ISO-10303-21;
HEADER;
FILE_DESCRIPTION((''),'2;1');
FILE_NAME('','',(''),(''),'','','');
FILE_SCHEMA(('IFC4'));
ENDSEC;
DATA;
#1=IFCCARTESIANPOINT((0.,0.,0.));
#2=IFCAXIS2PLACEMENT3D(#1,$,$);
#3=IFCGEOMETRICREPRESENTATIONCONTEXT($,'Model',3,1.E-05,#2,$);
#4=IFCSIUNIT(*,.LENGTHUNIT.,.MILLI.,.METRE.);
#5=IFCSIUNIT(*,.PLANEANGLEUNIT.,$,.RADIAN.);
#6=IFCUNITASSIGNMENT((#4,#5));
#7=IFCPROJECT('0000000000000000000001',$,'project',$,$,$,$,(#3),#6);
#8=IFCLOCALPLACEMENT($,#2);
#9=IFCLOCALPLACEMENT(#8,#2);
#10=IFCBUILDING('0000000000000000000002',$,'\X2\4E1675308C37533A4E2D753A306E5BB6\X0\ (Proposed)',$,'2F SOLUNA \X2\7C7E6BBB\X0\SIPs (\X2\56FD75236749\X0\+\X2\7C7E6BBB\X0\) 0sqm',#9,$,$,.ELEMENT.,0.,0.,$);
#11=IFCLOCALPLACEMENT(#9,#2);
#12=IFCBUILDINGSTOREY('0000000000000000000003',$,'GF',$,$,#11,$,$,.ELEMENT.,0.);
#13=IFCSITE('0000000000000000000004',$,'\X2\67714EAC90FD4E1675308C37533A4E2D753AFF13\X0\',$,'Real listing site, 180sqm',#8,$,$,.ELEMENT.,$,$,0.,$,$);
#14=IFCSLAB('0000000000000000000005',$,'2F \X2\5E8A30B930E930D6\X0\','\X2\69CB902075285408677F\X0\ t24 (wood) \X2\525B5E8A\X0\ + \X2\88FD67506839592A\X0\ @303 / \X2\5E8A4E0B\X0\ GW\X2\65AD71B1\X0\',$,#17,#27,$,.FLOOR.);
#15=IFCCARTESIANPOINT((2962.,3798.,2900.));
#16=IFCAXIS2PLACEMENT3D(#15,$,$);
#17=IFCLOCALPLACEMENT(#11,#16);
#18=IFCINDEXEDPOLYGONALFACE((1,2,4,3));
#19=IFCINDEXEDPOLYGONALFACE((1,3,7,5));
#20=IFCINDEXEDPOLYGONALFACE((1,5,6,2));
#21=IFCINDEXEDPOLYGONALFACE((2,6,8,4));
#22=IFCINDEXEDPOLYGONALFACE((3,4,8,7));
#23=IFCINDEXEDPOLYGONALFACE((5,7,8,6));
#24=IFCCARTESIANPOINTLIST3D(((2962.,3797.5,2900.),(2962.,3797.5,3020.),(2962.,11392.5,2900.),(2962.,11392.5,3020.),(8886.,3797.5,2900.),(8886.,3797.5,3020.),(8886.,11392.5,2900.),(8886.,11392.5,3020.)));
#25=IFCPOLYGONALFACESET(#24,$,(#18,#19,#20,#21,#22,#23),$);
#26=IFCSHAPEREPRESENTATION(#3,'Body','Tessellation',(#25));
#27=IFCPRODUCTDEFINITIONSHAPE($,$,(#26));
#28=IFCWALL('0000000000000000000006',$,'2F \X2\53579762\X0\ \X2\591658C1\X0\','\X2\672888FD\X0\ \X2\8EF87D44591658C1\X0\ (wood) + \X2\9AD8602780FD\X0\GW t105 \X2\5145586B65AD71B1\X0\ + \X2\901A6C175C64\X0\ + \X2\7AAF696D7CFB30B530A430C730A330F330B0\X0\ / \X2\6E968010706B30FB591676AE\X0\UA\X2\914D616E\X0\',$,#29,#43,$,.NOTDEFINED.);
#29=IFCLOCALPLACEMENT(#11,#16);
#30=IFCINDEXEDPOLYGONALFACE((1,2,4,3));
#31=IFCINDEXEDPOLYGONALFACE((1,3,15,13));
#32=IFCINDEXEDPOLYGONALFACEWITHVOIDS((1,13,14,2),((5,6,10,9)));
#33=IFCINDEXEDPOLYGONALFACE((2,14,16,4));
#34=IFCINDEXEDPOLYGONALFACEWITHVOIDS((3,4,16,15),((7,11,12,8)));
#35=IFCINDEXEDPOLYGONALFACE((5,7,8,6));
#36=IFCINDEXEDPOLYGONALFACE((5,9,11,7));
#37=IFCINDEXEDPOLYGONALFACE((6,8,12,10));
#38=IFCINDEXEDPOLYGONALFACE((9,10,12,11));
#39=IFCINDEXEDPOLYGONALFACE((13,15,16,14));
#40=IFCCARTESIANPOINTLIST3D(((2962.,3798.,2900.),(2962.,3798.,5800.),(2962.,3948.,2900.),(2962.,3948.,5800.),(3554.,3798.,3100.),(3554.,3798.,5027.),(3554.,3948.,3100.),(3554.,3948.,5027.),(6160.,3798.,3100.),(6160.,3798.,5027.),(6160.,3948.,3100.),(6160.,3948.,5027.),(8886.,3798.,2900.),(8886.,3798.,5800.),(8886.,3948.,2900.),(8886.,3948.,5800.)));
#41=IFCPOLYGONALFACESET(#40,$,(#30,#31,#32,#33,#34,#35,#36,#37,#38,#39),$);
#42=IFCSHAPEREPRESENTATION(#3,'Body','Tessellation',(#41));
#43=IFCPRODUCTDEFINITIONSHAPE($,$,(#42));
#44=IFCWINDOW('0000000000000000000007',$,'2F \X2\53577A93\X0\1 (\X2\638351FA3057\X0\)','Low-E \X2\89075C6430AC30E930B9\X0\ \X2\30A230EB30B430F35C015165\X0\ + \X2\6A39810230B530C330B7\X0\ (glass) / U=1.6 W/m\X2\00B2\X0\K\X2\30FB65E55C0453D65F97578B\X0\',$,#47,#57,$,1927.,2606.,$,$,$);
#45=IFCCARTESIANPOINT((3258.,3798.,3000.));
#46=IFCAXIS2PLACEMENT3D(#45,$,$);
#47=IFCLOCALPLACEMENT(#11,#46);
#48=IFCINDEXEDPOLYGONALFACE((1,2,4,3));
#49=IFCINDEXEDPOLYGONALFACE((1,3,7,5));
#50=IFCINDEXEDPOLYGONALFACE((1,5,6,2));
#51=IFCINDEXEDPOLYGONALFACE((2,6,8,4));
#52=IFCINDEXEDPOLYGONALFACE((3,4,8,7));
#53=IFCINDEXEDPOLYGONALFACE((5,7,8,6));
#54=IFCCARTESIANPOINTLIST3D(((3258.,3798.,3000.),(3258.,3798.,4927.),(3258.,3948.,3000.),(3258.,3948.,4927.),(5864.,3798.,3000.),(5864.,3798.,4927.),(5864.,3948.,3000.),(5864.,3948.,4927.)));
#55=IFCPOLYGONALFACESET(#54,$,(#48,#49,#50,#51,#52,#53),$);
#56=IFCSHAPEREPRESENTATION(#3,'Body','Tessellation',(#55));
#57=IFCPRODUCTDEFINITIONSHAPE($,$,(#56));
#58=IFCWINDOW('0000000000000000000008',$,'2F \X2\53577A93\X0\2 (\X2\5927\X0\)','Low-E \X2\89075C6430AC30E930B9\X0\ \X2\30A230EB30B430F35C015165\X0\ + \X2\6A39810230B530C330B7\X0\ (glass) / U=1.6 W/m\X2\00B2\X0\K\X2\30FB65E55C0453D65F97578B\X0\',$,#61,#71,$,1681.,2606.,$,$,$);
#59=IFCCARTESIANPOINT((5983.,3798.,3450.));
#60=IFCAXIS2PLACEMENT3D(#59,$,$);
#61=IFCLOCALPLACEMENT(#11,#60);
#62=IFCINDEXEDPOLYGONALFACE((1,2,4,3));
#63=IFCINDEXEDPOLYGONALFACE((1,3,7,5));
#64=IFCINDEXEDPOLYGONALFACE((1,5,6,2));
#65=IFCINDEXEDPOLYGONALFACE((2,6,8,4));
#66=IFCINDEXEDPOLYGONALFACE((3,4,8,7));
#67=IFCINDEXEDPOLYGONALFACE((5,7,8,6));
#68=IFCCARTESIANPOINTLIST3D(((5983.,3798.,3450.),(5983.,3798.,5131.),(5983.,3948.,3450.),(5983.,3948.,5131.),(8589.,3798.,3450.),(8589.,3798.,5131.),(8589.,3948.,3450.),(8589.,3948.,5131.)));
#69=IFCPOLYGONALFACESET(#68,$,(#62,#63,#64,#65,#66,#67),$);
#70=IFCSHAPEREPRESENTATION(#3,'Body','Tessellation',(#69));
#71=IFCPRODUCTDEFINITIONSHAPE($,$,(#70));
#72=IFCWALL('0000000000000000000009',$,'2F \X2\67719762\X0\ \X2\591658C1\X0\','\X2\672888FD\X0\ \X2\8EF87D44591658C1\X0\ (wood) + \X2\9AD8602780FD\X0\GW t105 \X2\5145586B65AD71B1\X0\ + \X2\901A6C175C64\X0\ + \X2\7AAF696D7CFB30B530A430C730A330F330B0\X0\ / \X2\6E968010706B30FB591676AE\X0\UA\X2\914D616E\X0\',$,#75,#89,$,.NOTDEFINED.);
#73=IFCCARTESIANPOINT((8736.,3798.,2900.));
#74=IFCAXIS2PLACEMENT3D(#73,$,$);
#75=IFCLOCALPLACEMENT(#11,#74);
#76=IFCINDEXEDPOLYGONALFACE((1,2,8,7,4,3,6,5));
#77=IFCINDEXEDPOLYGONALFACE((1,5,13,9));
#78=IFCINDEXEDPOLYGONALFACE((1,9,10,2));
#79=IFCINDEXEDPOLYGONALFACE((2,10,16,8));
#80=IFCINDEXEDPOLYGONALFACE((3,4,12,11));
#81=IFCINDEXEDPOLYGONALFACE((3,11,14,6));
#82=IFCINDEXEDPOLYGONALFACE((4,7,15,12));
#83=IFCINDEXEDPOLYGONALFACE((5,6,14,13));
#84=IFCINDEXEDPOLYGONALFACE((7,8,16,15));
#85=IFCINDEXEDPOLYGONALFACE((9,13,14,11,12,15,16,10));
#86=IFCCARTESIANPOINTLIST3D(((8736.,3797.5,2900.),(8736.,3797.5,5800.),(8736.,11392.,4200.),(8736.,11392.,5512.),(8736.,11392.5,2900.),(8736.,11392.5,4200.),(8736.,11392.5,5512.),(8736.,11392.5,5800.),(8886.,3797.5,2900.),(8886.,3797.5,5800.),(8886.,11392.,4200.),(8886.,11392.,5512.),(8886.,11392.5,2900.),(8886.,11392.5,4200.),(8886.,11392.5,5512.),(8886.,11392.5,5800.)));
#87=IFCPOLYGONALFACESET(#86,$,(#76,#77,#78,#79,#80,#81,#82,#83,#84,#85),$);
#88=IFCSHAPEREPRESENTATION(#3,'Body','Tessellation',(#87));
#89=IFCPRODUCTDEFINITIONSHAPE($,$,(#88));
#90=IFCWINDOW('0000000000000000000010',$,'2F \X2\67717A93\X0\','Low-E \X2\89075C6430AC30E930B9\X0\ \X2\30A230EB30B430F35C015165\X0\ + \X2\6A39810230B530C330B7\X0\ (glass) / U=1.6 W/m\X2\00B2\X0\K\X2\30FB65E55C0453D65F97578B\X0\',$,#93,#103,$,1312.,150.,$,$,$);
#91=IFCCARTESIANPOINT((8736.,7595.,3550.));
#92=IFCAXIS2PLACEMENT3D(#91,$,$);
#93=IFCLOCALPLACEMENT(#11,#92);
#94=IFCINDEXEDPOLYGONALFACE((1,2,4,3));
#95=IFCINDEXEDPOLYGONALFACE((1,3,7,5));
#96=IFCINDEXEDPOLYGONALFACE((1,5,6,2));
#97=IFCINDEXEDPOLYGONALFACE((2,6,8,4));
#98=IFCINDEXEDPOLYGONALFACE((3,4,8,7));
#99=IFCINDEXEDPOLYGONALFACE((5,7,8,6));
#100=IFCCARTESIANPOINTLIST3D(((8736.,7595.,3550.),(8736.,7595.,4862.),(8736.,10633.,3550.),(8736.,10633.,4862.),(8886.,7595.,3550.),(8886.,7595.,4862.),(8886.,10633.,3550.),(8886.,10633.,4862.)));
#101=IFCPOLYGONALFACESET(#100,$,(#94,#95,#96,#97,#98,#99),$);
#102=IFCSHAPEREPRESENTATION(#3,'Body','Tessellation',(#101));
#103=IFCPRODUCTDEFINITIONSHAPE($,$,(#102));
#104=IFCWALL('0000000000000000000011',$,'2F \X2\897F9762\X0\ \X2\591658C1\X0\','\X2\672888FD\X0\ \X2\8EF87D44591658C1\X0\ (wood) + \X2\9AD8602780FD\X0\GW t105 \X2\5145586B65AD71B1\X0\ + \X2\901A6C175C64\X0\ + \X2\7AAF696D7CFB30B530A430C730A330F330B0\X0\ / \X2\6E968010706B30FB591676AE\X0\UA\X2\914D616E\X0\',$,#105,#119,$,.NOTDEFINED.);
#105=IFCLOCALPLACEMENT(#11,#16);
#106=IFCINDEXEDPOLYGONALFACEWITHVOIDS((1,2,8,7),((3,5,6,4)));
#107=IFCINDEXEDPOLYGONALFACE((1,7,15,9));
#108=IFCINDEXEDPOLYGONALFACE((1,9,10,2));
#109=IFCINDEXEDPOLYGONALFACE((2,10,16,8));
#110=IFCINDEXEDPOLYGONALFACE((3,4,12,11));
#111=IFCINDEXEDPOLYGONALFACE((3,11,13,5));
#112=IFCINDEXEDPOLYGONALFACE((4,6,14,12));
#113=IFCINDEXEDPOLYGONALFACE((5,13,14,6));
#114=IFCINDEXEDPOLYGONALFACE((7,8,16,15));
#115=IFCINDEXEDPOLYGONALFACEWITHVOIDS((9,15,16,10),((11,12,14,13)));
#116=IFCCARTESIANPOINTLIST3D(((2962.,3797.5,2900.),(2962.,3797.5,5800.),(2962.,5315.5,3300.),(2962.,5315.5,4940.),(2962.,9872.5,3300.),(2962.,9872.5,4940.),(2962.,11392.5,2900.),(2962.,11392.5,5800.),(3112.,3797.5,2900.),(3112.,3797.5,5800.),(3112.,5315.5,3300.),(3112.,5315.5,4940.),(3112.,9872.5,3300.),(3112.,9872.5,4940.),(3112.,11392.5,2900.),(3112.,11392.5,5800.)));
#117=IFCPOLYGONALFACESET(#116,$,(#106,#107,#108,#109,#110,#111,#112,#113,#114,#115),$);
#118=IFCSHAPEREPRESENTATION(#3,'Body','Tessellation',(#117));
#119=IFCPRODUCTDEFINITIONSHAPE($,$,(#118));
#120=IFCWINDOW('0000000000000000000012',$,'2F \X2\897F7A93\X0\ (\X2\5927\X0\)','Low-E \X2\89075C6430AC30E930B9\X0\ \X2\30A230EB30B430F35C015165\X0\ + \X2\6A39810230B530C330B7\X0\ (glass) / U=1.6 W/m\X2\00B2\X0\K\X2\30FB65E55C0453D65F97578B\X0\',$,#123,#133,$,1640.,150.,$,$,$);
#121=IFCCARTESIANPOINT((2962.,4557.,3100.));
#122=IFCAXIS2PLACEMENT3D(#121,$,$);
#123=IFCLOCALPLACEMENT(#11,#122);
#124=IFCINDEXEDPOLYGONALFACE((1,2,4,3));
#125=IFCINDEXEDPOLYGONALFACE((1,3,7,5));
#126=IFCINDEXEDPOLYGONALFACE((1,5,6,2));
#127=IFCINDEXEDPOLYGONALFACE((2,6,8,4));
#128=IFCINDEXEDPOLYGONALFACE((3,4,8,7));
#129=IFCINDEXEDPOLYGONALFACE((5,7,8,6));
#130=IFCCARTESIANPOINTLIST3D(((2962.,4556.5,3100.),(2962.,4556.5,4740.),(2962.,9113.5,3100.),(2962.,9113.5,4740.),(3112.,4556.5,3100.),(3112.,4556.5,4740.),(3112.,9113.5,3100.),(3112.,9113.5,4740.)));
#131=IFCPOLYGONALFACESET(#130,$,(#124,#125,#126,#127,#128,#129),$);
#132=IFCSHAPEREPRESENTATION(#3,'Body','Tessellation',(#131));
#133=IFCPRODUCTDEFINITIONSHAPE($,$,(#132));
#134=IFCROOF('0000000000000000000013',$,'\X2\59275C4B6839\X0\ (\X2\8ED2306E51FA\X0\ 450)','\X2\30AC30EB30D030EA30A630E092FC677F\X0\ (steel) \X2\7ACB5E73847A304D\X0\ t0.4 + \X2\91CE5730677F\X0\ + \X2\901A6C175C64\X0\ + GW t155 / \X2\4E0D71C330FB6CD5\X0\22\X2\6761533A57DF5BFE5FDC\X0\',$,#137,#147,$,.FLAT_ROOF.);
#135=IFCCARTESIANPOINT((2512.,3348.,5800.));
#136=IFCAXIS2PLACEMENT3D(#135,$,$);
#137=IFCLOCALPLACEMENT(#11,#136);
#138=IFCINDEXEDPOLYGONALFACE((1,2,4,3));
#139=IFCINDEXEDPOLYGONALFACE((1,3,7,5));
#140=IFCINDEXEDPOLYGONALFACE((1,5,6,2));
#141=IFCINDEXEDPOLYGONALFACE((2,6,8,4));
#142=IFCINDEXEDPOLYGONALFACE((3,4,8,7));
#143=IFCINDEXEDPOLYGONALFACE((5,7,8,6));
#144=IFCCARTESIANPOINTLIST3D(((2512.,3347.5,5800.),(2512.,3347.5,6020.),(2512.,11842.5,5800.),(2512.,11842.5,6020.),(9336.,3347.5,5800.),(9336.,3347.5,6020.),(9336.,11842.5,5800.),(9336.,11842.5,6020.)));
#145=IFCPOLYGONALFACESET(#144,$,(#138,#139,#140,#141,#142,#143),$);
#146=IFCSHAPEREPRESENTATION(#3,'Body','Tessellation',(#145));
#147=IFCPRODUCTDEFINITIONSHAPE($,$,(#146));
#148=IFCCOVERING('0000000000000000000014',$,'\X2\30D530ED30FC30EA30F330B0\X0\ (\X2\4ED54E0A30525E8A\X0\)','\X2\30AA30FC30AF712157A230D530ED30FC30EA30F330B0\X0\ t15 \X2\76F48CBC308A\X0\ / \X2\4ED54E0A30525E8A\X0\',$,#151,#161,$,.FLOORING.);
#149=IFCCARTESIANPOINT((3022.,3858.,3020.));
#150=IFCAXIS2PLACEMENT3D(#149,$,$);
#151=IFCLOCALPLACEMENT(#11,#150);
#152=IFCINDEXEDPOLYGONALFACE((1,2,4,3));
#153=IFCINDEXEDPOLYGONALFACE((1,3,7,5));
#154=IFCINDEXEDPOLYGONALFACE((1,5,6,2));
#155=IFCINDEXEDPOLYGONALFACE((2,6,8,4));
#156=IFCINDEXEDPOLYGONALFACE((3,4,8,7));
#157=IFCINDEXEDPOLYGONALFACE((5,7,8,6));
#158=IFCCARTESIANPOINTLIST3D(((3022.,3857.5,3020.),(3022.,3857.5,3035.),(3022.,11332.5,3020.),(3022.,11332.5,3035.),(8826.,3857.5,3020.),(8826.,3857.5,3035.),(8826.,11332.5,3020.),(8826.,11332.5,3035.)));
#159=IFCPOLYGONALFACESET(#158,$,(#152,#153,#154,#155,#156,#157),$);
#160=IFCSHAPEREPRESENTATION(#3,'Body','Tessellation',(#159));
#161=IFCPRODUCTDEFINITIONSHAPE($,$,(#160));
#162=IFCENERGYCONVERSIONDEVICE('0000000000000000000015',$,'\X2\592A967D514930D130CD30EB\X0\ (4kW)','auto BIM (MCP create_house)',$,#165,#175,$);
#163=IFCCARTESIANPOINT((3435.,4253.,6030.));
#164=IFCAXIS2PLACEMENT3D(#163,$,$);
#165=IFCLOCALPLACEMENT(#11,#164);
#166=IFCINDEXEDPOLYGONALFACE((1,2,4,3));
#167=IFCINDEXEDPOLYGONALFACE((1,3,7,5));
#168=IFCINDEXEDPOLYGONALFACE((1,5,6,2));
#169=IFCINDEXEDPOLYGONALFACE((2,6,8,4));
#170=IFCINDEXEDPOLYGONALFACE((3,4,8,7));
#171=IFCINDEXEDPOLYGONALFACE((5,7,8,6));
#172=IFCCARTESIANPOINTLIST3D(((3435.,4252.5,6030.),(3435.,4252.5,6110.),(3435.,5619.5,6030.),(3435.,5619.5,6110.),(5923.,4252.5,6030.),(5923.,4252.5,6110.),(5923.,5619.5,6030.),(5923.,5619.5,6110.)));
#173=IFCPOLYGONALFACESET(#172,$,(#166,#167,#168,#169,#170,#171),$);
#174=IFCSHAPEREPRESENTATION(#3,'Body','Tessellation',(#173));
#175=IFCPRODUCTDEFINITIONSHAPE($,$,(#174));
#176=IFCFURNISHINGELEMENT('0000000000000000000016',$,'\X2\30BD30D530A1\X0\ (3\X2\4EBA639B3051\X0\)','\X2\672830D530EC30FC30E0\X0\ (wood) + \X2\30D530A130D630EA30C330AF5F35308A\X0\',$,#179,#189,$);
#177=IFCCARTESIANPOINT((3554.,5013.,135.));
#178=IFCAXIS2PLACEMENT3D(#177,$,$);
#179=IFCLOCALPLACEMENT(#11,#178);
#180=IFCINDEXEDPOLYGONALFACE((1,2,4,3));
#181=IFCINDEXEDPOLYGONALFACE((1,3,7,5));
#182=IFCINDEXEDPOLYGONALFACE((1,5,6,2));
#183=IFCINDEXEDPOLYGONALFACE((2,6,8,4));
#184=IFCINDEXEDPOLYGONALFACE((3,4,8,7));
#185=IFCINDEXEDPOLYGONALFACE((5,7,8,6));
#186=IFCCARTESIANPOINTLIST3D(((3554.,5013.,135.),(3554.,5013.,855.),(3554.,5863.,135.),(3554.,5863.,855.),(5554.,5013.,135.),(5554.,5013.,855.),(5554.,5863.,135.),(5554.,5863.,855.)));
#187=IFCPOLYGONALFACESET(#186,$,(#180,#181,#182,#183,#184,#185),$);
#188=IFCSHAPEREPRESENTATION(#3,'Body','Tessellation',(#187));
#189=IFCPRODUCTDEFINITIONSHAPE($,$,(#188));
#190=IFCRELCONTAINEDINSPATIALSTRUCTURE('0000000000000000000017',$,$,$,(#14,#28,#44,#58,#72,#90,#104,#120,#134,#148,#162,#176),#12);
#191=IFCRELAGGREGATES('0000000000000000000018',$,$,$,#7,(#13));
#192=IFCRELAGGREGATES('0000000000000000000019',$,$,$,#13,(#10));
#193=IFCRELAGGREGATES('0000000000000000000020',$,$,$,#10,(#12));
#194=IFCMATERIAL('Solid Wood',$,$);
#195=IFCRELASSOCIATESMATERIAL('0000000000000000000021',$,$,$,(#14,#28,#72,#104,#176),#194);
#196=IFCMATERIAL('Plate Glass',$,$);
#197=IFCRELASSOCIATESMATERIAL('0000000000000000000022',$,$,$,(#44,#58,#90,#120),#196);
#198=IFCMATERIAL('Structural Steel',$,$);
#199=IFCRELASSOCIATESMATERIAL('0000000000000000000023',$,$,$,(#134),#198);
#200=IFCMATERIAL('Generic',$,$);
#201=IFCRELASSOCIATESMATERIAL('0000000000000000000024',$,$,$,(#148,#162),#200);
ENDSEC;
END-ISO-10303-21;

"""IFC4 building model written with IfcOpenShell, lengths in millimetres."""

from ifc_helpers import new_model, si_unit, frame, frame_2d, origin, place, context, project, spatial, rectangle, extrude, material, element, fill, save


model = new_model("IFC4")

# Units and contexts
model_context = context("Model", 3, precision=1e-05, world=origin())
ifc_project = project(units=[si_unit("LENGTHUNIT", "METRE", prefix="MILLI"), si_unit("PLANEANGLEUNIT", "RADIAN")], contexts=[model_context])

# Site, building, storey
site_placement = place(None, origin())
site = spatial("IfcSite", under=ifc_project, at=site_placement, Name="東京都世田谷区中町３", ObjectType="Real listing site, 180sqm", CompositionType="ELEMENT", RefElevation=0.0)
building_placement = place(site_placement, origin())
building = spatial("IfcBuilding", under=site, at=building_placement, Name="世田谷区中町の家 (Proposed)", ObjectType="2F SOLUNA 籾殻SIPs (国産杉+籾殻) 0sqm", CompositionType="ELEMENT", ElevationOfRefHeight=0.0, ElevationOfTerrain=0.0)
storey_placement = place(building_placement, origin())
storey = spatial("IfcBuildingStorey", under=building, at=storey_placement, Name="GF", CompositionType="ELEMENT", Elevation=0.0)

# Slab
ifc_material_1 = material(Name="Solid Wood")
slab_placement = place(storey_placement, frame((2962.0, 3798.0, 2900.0)))
element("IfcSlab", 1, at=slab_placement, inside=storey, material=ifc_material_1, Name="2F 床スラブ", Description="構造用合板 t24 (wood) 剛床 + 製材根太 @303 / 床下 GW断熱", PredefinedType="FLOOR", context=model_context, shape_type="SweptSolid", body=[
    extrude(rectangle(XDim=5924.0, YDim=7595.0, at=frame_2d((2962.0, 3797.0))), frame((2962.0, 3798.0, 2900.0)), (0.0, 0.0, 1.0), 120.0),
])

# Wall, openings, windows
wall_1_placement = place(storey_placement, frame((2962.0, 3798.0, 2900.0)))
wall_1 = element("IfcWall", 2, at=wall_1_placement, inside=storey, material=ifc_material_1, Name="2F 南面 外壁", Description="木製 軸組外壁 (wood) + 高性能GW t105 充填断熱 + 通気層 + 窯業系サイディング / 準耐火・外皮UA配慮", PredefinedType="NOTDEFINED", context=model_context, shape_type="SweptSolid", body=[
    extrude(rectangle(XDim=5924.0, YDim=150.0, at=frame_2d((2962.0, 75.0))), frame((2962.0, 3798.0, 2900.0)), (0.0, 0.0, 1.0), 2900.0),
])
opening_1_placement = place(storey_placement, frame((3258.0, 3798.0, 3000.0)))
opening_1 = element("IfcOpeningElement", 3, at=opening_1_placement, cuts=wall_1, PredefinedType="NOTDEFINED", context=model_context, shape_type="SweptSolid", body=[
    extrude(rectangle(XDim=2606.0, YDim=150.0, at=frame_2d((1303.0, 75.0))), frame((3258.0, 3798.0, 3000.0)), (0.0, 0.0, 1.0), 1927.0),
])
opening_2_placement = place(storey_placement, frame((5983.0, 3798.0, 3450.0)))
opening_2 = element("IfcOpeningElement", 4, at=opening_2_placement, cuts=wall_1, PredefinedType="NOTDEFINED", context=model_context, shape_type="SweptSolid", body=[
    extrude(rectangle(XDim=2606.0, YDim=150.0, at=frame_2d((1303.0, 75.0))), frame((5983.0, 3798.0, 3450.0)), (0.0, 0.0, 1.0), 1681.0),
])
ifc_material_2 = material(Name="Plate Glass")
window_1_placement = place(storey_placement, frame((3258.0, 3798.0, 3000.0)))
window_1 = element("IfcWindow", 5, at=window_1_placement, inside=storey, material=ifc_material_2, Name="2F 南窓1 (掃出し)", Description="Low-E 複層ガラス アルゴン封入 + 樹脂サッシ (glass) / U=1.6 W/m²K・日射取得型", OverallHeight=1927.0, OverallWidth=2606.0, context=model_context, shape_type="SweptSolid", body=[
    extrude(rectangle(XDim=2606.0, YDim=150.0, at=frame_2d((1303.0, 75.0))), frame((3258.0, 3798.0, 3000.0)), (0.0, 0.0, 1.0), 1927.0),
])
fill(opening_1, window_1)
window_2_placement = place(storey_placement, frame((5983.0, 3798.0, 3450.0)))
window_2 = element("IfcWindow", 6, at=window_2_placement, inside=storey, material=ifc_material_2, Name="2F 南窓2 (大)", Description="Low-E 複層ガラス アルゴン封入 + 樹脂サッシ (glass) / U=1.6 W/m²K・日射取得型", OverallHeight=1681.0, OverallWidth=2606.0, context=model_context, shape_type="SweptSolid", body=[
    extrude(rectangle(XDim=2606.0, YDim=150.0, at=frame_2d((1303.0, 75.0))), frame((5983.0, 3798.0, 3450.0)), (0.0, 0.0, 1.0), 1681.0),
])
fill(opening_2, window_2)

# Walls, openings, windows
wall_2_placement = place(storey_placement, frame((8736.0, 3798.0, 2900.0)))
wall_2 = element("IfcWall", 7, at=wall_2_placement, inside=storey, material=ifc_material_1, Name="2F 東面 外壁", Description="木製 軸組外壁 (wood) + 高性能GW t105 充填断熱 + 通気層 + 窯業系サイディング / 準耐火・外皮UA配慮", PredefinedType="NOTDEFINED", context=model_context, shape_type="SweptSolid", body=[
    extrude(rectangle(XDim=150.0, YDim=7595.0, at=frame_2d((75.0, 3797.0))), frame((8736.0, 3798.0, 2900.0)), (0.0, 0.0, 1.0), 2900.0),
])
opening_3_placement = place(storey_placement, frame((8736.0, 7595.0, 3550.0)))
opening_3 = element("IfcOpeningElement", 8, at=opening_3_placement, cuts=wall_2, PredefinedType="NOTDEFINED", context=model_context, shape_type="SweptSolid", body=[
    extrude(rectangle(XDim=150.0, YDim=3038.0, at=frame_2d((75.0, 1519.0))), frame((8736.0, 7595.0, 3550.0)), (0.0, 0.0, 1.0), 1312.0),
])
window_3_placement = place(storey_placement, frame((8736.0, 7595.0, 3550.0)))
window_3 = element("IfcWindow", 9, at=window_3_placement, inside=storey, material=ifc_material_2, Name="2F 東窓", Description="Low-E 複層ガラス アルゴン封入 + 樹脂サッシ (glass) / U=1.6 W/m²K・日射取得型", OverallHeight=1312.0, OverallWidth=150.0, context=model_context, shape_type="SweptSolid", body=[
    extrude(rectangle(XDim=150.0, YDim=3038.0, at=frame_2d((75.0, 1519.0))), frame((8736.0, 7595.0, 3550.0)), (0.0, 0.0, 1.0), 1312.0),
])
fill(opening_3, window_3)
wall_3_placement = place(storey_placement, frame((2962.0, 3798.0, 2900.0)))
wall_3 = element("IfcWall", 10, at=wall_3_placement, inside=storey, material=ifc_material_1, Name="2F 西面 外壁", Description="木製 軸組外壁 (wood) + 高性能GW t105 充填断熱 + 通気層 + 窯業系サイディング / 準耐火・外皮UA配慮", PredefinedType="NOTDEFINED", context=model_context, shape_type="SweptSolid", body=[
    extrude(rectangle(XDim=150.0, YDim=7595.0, at=frame_2d((75.0, 3797.0))), frame((2962.0, 3798.0, 2900.0)), (0.0, 0.0, 1.0), 2900.0),
])
opening_4_placement = place(storey_placement, frame((2962.0, 4557.0, 3100.0)))
opening_4 = element("IfcOpeningElement", 11, at=opening_4_placement, cuts=wall_3, PredefinedType="NOTDEFINED", context=model_context, shape_type="SweptSolid", body=[
    extrude(rectangle(XDim=150.0, YDim=4557.0, at=frame_2d((75.0, 2278.0))), frame((2962.0, 4557.0, 3100.0)), (0.0, 0.0, 1.0), 1640.0),
])
window_4_placement = place(storey_placement, frame((2962.0, 4557.0, 3100.0)))
window_4 = element("IfcWindow", 12, at=window_4_placement, inside=storey, material=ifc_material_2, Name="2F 西窓 (大)", Description="Low-E 複層ガラス アルゴン封入 + 樹脂サッシ (glass) / U=1.6 W/m²K・日射取得型", OverallHeight=1640.0, OverallWidth=150.0, context=model_context, shape_type="SweptSolid", body=[
    extrude(rectangle(XDim=150.0, YDim=4557.0, at=frame_2d((75.0, 2278.0))), frame((2962.0, 4557.0, 3100.0)), (0.0, 0.0, 1.0), 1640.0),
])
fill(opening_4, window_4)

# Roof
ifc_material_3 = material(Name="Structural Steel")
roof_placement = place(storey_placement, frame((2512.0, 3348.0, 5800.0)))
element("IfcRoof", 13, at=roof_placement, inside=storey, material=ifc_material_3, Name="大屋根 (軒の出 450)", Description="ガルバリウム鋼板 (steel) 立平葺き t0.4 + 野地板 + 通気層 + GW t155 / 不燃・法22条区域対応", PredefinedType="FLAT_ROOF", context=model_context, shape_type="SweptSolid", body=[
    extrude(rectangle(XDim=6824.0, YDim=8495.0, at=frame_2d((3412.0, 4247.0))), frame((2512.0, 3348.0, 5800.0)), (0.0, 0.0, 1.0), 220.0),
])

# Covering
ifc_material_4 = material(Name="Generic")
covering_placement = place(storey_placement, frame((3022.0, 3858.0, 3020.0)))
element("IfcCovering", 14, at=covering_placement, inside=storey, material=ifc_material_4, Name="フローリング (仕上げ床)", Description="オーク無垢フローリング t15 直貼り / 仕上げ床", PredefinedType="FLOORING", context=model_context, shape_type="SweptSolid", body=[
    extrude(rectangle(XDim=5804.0, YDim=7475.0, at=frame_2d((2902.0, 3737.0))), frame((3022.0, 3858.0, 3020.0)), (0.0, 0.0, 1.0), 15.0),
])

# Energy conversion device
energy_conversion_device_placement = place(storey_placement, frame((3435.0, 4253.0, 6030.0)))
element("IfcEnergyConversionDevice", 15, at=energy_conversion_device_placement, inside=storey, material=ifc_material_4, Name="太陽光パネル (4kW)", Description="auto BIM (MCP create_house)", context=model_context, shape_type="SweptSolid", body=[
    extrude(rectangle(XDim=2488.0, YDim=1367.0, at=frame_2d((1244.0, 683.0))), frame((3435.0, 4253.0, 6030.0)), (0.0, 0.0, 1.0), 80.0),
])

# Furnishing element
furnishing_1_placement = place(storey_placement, frame((3554.0, 5013.0, 135.0)))
element("IfcFurnishingElement", 16, at=furnishing_1_placement, inside=storey, material=ifc_material_1, Name="ソファ (3人掛け)", Description="木フレーム (wood) + ファブリック張り", context=model_context, shape_type="SweptSolid", body=[
    extrude(rectangle(XDim=2000.0, YDim=850.0, at=frame_2d((1000.0, 425.0))), frame((3554.0, 5013.0, 135.0)), (0.0, 0.0, 1.0), 720.0),
])

save(model, "model.ifc")
